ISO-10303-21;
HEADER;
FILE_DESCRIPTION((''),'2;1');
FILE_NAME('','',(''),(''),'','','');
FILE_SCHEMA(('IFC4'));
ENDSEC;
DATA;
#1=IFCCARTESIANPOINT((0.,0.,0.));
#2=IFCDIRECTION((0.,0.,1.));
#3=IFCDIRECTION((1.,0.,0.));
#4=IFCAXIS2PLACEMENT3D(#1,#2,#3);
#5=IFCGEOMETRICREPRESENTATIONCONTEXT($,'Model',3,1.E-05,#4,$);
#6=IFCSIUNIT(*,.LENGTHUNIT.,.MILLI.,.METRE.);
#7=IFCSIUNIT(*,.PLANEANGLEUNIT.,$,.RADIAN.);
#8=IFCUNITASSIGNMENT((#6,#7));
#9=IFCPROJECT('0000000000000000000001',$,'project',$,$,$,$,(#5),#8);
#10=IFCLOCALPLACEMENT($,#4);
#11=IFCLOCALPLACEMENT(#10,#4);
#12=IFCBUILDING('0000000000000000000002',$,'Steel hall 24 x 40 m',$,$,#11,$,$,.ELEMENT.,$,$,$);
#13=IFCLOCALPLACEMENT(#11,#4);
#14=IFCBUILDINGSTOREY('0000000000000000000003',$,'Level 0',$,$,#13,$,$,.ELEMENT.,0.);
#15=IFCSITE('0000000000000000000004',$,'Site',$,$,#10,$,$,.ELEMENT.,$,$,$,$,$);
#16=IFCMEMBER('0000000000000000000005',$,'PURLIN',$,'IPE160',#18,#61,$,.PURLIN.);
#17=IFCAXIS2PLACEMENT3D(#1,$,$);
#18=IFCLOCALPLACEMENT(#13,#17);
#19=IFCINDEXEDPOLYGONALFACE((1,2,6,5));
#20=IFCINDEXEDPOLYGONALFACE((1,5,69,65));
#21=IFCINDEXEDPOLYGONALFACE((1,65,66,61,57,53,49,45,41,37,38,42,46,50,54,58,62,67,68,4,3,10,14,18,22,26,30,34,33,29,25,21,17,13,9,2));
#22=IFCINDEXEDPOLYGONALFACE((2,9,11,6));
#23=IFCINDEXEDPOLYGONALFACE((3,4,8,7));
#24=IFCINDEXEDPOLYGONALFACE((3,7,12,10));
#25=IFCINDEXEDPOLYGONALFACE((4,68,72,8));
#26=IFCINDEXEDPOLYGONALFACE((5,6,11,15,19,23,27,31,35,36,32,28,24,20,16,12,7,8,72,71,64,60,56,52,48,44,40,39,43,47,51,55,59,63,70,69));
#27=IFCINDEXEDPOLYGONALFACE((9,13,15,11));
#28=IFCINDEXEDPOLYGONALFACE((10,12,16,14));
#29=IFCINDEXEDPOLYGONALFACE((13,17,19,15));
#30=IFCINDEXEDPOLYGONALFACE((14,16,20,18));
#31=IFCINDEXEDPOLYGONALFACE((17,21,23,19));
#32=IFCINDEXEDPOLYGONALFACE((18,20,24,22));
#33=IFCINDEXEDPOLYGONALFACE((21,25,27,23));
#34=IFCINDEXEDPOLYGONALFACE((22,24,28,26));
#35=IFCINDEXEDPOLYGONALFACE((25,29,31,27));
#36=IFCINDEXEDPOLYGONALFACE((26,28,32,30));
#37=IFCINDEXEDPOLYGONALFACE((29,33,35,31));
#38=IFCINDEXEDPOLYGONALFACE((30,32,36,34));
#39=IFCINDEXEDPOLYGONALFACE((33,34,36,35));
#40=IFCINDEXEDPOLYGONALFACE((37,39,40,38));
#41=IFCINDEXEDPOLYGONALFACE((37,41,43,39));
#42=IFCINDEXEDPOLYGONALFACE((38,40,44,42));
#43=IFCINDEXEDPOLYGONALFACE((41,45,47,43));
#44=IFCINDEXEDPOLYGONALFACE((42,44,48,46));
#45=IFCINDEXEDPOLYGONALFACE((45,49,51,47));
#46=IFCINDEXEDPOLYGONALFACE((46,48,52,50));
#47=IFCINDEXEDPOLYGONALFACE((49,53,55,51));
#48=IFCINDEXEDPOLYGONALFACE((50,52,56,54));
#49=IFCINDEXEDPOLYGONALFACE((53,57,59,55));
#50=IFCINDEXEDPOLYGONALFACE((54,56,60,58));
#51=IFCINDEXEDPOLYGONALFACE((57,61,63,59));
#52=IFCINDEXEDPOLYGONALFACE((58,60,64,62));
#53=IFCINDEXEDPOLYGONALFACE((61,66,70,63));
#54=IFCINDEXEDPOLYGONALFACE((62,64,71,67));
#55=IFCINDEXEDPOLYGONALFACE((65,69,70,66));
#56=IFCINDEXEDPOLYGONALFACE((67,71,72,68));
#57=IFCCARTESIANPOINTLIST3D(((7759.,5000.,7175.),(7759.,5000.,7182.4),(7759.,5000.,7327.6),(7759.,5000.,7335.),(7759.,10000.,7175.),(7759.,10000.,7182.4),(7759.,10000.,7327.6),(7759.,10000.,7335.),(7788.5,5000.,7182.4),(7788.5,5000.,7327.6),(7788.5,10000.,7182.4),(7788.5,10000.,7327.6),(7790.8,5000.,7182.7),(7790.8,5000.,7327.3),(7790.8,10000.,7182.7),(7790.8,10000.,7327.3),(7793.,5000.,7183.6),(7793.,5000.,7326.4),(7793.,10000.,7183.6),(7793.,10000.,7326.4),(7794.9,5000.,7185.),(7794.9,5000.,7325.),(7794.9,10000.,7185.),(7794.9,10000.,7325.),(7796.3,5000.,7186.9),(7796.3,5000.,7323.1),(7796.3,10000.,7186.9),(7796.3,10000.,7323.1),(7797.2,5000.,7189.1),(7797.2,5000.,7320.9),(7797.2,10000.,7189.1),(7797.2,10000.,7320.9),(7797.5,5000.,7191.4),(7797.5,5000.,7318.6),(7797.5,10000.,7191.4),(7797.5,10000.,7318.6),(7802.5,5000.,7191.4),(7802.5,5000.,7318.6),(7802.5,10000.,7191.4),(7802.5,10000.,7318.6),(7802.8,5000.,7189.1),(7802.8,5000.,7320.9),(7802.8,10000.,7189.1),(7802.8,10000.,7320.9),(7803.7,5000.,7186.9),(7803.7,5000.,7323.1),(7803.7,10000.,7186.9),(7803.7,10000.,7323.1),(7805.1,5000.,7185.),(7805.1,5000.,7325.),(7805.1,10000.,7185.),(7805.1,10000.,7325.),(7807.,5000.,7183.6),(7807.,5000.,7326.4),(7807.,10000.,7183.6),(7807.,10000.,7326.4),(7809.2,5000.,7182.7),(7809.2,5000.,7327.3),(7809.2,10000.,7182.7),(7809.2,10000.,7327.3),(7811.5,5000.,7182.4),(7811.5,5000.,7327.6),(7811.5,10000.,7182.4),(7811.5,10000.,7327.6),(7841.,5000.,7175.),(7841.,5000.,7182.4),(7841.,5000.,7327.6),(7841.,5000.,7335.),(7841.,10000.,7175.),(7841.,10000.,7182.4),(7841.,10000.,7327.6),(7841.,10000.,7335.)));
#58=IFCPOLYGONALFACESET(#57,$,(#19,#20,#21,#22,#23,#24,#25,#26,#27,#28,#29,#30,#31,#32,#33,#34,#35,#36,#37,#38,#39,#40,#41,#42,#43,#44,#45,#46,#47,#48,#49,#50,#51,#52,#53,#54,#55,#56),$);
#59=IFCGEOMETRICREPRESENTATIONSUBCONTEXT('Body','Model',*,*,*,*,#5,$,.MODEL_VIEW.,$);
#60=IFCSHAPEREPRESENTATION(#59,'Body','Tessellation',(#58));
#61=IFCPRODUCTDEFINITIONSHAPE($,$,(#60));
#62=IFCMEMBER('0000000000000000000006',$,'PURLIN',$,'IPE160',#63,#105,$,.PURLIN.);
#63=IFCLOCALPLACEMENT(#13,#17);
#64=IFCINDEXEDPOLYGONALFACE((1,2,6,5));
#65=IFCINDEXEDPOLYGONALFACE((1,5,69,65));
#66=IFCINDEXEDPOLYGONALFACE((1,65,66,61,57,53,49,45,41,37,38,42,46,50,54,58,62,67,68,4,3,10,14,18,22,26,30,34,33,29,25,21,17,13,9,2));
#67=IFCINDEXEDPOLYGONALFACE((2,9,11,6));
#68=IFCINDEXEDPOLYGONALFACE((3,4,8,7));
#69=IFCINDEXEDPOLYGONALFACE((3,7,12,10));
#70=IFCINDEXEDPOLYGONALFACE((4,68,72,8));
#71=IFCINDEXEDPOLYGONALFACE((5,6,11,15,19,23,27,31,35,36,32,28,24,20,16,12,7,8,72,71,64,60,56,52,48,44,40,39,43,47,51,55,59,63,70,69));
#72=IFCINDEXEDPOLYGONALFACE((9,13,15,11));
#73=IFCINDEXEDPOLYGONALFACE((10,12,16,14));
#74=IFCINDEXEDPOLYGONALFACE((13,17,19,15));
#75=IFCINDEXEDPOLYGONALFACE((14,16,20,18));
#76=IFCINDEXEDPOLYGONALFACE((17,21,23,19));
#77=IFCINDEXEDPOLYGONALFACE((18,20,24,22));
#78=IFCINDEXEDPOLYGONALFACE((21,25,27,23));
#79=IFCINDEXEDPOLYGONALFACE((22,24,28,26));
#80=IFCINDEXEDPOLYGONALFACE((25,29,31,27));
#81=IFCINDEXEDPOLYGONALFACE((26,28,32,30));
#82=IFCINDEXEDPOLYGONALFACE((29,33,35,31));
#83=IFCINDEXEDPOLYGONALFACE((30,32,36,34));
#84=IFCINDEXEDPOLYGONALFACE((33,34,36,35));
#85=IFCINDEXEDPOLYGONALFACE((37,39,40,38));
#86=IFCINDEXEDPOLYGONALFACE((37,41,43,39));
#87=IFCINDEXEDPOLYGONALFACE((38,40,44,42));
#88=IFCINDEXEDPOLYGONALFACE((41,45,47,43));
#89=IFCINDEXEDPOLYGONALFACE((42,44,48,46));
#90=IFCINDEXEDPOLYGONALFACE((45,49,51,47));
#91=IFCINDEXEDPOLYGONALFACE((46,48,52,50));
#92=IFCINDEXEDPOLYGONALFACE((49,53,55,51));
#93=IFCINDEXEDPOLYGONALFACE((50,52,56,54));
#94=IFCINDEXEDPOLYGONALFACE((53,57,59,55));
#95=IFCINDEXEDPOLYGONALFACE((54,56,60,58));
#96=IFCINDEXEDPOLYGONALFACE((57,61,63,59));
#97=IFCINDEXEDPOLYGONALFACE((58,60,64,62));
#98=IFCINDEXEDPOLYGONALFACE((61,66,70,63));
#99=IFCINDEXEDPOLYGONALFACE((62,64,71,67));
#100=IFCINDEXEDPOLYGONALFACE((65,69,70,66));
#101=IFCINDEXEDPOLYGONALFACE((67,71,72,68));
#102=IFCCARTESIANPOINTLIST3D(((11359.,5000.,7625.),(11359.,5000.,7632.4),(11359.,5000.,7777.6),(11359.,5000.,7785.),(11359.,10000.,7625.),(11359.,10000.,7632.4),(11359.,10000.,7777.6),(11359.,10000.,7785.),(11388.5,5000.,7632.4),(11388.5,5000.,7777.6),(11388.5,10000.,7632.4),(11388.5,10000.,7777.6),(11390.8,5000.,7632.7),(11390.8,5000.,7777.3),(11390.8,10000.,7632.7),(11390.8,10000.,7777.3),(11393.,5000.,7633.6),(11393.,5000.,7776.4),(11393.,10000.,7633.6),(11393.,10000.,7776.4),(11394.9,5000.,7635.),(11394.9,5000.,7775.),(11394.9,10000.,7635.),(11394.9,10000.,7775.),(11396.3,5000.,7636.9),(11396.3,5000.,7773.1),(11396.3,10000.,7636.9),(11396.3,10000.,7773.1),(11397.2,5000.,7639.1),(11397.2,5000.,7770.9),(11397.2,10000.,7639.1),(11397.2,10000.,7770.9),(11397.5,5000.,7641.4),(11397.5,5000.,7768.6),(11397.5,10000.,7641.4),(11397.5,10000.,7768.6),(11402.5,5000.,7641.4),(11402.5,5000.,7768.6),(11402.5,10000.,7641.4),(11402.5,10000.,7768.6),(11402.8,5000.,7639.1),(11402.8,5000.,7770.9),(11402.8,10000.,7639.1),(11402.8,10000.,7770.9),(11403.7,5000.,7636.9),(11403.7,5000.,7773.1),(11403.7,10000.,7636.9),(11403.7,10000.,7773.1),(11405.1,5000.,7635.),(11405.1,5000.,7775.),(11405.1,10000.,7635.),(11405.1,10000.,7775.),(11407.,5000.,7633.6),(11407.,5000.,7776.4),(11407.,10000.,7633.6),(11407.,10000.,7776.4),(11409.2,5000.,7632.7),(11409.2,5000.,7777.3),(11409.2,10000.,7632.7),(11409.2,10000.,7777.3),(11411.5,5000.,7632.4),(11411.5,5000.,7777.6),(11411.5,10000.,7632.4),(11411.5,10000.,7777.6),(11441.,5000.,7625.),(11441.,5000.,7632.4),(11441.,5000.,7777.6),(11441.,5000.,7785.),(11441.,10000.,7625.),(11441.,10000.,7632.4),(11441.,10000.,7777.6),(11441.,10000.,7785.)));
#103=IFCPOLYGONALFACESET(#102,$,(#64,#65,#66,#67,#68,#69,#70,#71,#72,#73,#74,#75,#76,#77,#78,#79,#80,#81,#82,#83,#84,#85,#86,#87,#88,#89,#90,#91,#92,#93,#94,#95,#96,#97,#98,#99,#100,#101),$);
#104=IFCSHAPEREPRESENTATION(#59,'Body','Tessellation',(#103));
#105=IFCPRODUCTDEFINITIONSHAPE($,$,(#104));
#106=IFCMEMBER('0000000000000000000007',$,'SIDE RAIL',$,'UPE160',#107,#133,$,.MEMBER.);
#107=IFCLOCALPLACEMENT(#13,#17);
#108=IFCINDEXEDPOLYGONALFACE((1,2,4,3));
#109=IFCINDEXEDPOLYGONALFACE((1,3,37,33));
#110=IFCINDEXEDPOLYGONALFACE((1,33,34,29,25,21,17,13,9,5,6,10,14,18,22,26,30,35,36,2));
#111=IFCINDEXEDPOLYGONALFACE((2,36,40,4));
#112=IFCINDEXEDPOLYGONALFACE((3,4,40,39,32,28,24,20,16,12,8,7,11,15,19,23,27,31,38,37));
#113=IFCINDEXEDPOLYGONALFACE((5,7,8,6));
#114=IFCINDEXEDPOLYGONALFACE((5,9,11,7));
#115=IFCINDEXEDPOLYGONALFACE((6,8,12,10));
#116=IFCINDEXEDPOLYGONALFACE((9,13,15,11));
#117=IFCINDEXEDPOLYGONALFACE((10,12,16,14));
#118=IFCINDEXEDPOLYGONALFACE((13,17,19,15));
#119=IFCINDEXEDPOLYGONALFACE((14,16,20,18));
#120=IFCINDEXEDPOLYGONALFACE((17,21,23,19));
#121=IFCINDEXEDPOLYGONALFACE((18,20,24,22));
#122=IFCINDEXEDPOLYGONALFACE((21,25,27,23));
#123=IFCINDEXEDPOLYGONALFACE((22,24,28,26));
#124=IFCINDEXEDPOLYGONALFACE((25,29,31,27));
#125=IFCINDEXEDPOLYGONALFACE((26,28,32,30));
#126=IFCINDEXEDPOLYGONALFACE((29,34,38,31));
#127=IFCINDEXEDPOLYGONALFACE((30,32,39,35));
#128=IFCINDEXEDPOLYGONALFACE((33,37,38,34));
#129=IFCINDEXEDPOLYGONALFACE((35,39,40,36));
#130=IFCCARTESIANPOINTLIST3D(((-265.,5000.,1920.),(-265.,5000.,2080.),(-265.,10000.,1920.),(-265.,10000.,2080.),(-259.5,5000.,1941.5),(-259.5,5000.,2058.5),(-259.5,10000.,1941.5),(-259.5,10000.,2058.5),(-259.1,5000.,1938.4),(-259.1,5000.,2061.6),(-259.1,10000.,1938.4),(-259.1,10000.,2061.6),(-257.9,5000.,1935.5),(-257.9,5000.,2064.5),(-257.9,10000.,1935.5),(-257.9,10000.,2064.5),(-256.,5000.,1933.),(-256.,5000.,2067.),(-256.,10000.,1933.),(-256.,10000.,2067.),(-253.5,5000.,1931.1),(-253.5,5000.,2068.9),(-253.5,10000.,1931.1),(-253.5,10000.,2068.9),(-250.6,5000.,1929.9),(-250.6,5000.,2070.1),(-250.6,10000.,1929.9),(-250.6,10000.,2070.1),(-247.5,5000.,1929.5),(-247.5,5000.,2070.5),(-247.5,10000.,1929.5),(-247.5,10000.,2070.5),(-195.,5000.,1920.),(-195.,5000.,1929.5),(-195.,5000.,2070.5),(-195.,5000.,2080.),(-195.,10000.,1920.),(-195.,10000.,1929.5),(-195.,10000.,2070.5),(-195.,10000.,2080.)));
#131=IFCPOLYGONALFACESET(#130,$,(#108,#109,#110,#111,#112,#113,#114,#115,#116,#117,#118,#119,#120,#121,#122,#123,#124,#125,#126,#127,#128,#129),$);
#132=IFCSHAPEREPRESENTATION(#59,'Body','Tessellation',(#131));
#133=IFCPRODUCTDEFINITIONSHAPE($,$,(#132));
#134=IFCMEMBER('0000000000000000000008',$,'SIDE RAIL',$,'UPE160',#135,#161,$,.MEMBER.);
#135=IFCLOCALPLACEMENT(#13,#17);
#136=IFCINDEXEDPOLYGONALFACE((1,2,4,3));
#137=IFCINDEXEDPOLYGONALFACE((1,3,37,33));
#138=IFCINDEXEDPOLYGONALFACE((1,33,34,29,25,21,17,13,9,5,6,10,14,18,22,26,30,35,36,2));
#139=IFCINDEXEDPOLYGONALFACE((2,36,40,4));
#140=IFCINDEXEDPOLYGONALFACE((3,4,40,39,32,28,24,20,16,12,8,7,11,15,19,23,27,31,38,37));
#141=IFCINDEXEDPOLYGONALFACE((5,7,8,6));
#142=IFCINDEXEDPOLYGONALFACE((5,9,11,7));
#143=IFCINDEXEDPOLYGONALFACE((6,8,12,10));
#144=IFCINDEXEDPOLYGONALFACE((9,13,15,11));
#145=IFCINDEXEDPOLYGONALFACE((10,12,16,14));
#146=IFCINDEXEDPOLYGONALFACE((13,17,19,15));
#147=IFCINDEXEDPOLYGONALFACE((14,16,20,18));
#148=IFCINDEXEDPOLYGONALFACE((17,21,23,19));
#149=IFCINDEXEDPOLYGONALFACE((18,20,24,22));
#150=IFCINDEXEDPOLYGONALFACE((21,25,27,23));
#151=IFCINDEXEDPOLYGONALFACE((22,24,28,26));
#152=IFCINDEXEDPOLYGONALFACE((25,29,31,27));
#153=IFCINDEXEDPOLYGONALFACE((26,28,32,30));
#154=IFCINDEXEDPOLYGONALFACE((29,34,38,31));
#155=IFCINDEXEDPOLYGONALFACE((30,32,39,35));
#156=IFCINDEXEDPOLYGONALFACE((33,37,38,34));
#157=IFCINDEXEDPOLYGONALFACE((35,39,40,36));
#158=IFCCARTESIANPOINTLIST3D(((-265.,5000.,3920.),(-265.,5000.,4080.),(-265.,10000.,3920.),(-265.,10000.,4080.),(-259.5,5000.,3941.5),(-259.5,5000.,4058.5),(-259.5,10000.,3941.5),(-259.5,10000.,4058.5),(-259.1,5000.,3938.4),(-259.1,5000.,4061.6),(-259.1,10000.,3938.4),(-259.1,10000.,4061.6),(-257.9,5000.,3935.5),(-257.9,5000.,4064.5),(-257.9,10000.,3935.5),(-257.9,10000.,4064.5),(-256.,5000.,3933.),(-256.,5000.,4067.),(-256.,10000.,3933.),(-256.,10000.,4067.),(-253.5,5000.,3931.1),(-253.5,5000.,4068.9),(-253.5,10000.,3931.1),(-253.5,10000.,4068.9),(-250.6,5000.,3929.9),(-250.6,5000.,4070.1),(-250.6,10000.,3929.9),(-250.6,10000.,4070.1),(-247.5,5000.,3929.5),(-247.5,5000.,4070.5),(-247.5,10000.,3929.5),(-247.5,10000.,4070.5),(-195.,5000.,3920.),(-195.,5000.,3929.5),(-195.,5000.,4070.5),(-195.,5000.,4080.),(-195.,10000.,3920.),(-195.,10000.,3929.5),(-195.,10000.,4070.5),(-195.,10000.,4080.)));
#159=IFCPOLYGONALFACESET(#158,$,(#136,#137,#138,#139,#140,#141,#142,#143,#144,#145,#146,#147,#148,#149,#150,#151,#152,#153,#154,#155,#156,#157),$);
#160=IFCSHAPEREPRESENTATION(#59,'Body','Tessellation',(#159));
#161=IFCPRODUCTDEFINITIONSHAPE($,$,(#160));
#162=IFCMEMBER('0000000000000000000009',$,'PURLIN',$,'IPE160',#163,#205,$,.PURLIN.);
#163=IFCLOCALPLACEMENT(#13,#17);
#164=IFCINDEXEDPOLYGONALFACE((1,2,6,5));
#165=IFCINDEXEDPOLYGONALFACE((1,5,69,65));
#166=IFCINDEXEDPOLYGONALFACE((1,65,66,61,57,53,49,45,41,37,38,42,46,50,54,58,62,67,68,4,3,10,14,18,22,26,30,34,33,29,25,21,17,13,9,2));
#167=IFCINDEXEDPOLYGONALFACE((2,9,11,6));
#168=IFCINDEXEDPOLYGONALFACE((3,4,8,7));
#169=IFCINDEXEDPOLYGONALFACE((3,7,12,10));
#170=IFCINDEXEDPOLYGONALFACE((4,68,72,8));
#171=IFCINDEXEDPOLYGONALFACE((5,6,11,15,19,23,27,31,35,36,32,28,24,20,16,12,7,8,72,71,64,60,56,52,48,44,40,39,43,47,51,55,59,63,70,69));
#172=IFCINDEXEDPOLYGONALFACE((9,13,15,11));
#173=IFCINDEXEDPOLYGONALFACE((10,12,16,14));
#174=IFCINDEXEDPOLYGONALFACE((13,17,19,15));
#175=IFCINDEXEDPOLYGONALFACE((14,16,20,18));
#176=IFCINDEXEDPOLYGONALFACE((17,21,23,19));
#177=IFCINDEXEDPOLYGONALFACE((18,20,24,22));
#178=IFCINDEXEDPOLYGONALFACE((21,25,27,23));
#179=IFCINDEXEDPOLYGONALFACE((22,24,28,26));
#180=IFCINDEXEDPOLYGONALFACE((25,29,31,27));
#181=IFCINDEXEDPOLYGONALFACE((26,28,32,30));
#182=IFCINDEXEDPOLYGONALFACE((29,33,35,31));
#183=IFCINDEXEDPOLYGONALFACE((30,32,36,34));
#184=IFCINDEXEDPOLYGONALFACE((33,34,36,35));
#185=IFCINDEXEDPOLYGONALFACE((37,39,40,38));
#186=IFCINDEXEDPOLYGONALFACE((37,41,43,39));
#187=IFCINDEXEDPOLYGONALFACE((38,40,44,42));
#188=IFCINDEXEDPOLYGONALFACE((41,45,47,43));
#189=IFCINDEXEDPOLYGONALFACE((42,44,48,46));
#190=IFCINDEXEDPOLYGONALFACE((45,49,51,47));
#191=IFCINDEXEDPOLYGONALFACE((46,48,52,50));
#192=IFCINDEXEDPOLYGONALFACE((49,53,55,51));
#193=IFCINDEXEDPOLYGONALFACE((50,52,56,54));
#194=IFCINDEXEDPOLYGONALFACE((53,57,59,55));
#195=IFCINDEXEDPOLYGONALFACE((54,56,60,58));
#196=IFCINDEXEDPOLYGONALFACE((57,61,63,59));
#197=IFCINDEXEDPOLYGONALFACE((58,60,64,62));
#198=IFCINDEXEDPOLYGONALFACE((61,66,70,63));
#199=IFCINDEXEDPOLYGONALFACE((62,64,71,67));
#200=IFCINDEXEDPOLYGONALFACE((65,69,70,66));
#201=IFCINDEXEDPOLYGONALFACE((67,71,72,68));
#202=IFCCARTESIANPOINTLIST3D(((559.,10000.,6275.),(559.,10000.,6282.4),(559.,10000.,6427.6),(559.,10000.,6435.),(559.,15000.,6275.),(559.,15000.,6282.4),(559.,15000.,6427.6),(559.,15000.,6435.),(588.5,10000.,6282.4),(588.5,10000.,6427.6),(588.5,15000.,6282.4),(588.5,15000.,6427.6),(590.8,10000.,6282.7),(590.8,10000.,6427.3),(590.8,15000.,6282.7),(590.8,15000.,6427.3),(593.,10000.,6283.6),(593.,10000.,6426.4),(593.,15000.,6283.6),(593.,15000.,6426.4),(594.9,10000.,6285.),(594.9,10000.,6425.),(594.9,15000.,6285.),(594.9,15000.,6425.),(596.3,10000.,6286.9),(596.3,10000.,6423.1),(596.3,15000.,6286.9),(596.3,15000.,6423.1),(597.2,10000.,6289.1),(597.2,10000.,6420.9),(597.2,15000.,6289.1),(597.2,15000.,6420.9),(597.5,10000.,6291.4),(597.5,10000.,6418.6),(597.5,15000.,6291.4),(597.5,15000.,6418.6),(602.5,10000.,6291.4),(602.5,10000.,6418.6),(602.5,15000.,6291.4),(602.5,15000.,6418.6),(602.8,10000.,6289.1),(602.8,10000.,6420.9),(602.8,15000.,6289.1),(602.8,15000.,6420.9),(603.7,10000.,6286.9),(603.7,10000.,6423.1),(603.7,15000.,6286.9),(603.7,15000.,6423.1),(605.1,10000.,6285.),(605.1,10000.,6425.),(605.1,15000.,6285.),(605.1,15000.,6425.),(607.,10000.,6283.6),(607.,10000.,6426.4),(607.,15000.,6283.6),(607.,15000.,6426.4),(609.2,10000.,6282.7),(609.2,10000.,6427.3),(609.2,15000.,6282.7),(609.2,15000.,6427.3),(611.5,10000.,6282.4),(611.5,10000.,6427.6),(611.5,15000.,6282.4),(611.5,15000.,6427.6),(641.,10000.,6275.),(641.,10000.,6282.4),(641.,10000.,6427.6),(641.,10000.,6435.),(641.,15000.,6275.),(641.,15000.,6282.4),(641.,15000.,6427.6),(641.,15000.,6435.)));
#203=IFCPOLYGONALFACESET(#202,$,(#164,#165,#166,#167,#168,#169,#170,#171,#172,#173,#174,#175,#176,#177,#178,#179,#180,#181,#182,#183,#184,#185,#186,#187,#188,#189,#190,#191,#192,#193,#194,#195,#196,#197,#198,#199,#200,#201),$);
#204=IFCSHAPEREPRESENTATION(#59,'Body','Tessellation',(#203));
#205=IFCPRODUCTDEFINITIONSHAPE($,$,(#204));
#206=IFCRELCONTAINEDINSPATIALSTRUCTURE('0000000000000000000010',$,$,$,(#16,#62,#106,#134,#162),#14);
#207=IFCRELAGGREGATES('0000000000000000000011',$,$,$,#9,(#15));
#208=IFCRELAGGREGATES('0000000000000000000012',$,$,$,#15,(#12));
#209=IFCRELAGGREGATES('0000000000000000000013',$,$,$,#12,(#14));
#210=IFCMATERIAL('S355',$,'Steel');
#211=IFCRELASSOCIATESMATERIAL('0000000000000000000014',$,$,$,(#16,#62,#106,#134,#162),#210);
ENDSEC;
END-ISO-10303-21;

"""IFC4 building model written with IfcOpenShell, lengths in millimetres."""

from ifc_helpers import new_model, si_unit, frame, origin_with_axes, place, context, subcontext, project, spatial, i_section, u_section, extrude, material, element, save


model = new_model("IFC4")

# Units and contexts
model_context = context("Model", 3, precision=1e-05, world=origin_with_axes())
body_context = subcontext(model_context, "Body", "Model", "MODEL_VIEW")
ifc_project = project(units=[si_unit("LENGTHUNIT", "METRE", prefix="MILLI"), si_unit("PLANEANGLEUNIT", "RADIAN")], contexts=[model_context])

# Site, building, storey
site_placement = place(None, origin_with_axes())
site = spatial("IfcSite", under=ifc_project, at=site_placement, Name="Site", CompositionType="ELEMENT")
building_placement = place(site_placement, origin_with_axes())
building = spatial("IfcBuilding", under=site, at=building_placement, Name="Steel hall 24 x 40 m", CompositionType="ELEMENT")
storey_placement = place(building_placement, origin_with_axes())
storey = spatial("IfcBuildingStorey", under=building, at=storey_placement, Name="Level 0", CompositionType="ELEMENT", Elevation=0.0)

# Shared definitions
ifc_material = material(Name="S355", Category="Steel")

# Members
for number, where, z_axis, x_axis, name in (
    (1, (7800.0, 5000.0, 7255.0), (0.0, 1.0, 0.0), (1.0, 0.0, 0.0), "PURLIN"),
    (2, (11400.0, 5000.0, 7705.0), (0.0, 1.0, 0.0), (1.0, 0.0, 0.0), "PURLIN"),
):
    element("IfcMember", number, at=place(storey_placement, frame(where, z_axis=z_axis, x_axis=x_axis)), inside=storey, material=ifc_material, Name=name, ObjectType="IPE160", PredefinedType="PURLIN", context=body_context, shape_type="SweptSolid", body=[
        extrude(i_section(OverallWidth=82.0, OverallDepth=160.0, WebThickness=5.0, FlangeThickness=7.4, FilletRadius=9.0), origin_with_axes(), (0.0, 0.0, 1.0), 5000.0),
    ])
for number, where, z_axis, x_axis, name in (
    (3, (-230.0, 5000.0, 2000.0), (0.0, 1.0, 0.0), (1.0, 0.0, 0.0), "SIDE RAIL"),
    (4, (-230.0, 5000.0, 4000.0), (0.0, 1.0, 0.0), (1.0, 0.0, 0.0), "SIDE RAIL"),
):
    element("IfcMember", number, at=place(storey_placement, frame(where, z_axis=z_axis, x_axis=x_axis)), inside=storey, material=ifc_material, Name=name, ObjectType="UPE160", PredefinedType="MEMBER", context=body_context, shape_type="SweptSolid", body=[
        extrude(u_section(Depth=160.0, FlangeWidth=70.0, WebThickness=5.5, FlangeThickness=9.5, FilletRadius=12.0), origin_with_axes(), (0.0, 0.0, 1.0), 5000.0),
    ])
for number, where, z_axis, x_axis, name in (
    (5, (600.0, 10000.0, 6355.0), (0.0, 1.0, 0.0), (1.0, 0.0, 0.0), "PURLIN"),
):
    element("IfcMember", number, at=place(storey_placement, frame(where, z_axis=z_axis, x_axis=x_axis)), inside=storey, material=ifc_material, Name=name, ObjectType="IPE160", PredefinedType="PURLIN", context=body_context, shape_type="SweptSolid", body=[
        extrude(i_section(OverallWidth=82.0, OverallDepth=160.0, WebThickness=5.0, FlangeThickness=7.4, FilletRadius=9.0), origin_with_axes(), (0.0, 0.0, 1.0), 5000.0),
    ])

save(model, "model.ifc")
